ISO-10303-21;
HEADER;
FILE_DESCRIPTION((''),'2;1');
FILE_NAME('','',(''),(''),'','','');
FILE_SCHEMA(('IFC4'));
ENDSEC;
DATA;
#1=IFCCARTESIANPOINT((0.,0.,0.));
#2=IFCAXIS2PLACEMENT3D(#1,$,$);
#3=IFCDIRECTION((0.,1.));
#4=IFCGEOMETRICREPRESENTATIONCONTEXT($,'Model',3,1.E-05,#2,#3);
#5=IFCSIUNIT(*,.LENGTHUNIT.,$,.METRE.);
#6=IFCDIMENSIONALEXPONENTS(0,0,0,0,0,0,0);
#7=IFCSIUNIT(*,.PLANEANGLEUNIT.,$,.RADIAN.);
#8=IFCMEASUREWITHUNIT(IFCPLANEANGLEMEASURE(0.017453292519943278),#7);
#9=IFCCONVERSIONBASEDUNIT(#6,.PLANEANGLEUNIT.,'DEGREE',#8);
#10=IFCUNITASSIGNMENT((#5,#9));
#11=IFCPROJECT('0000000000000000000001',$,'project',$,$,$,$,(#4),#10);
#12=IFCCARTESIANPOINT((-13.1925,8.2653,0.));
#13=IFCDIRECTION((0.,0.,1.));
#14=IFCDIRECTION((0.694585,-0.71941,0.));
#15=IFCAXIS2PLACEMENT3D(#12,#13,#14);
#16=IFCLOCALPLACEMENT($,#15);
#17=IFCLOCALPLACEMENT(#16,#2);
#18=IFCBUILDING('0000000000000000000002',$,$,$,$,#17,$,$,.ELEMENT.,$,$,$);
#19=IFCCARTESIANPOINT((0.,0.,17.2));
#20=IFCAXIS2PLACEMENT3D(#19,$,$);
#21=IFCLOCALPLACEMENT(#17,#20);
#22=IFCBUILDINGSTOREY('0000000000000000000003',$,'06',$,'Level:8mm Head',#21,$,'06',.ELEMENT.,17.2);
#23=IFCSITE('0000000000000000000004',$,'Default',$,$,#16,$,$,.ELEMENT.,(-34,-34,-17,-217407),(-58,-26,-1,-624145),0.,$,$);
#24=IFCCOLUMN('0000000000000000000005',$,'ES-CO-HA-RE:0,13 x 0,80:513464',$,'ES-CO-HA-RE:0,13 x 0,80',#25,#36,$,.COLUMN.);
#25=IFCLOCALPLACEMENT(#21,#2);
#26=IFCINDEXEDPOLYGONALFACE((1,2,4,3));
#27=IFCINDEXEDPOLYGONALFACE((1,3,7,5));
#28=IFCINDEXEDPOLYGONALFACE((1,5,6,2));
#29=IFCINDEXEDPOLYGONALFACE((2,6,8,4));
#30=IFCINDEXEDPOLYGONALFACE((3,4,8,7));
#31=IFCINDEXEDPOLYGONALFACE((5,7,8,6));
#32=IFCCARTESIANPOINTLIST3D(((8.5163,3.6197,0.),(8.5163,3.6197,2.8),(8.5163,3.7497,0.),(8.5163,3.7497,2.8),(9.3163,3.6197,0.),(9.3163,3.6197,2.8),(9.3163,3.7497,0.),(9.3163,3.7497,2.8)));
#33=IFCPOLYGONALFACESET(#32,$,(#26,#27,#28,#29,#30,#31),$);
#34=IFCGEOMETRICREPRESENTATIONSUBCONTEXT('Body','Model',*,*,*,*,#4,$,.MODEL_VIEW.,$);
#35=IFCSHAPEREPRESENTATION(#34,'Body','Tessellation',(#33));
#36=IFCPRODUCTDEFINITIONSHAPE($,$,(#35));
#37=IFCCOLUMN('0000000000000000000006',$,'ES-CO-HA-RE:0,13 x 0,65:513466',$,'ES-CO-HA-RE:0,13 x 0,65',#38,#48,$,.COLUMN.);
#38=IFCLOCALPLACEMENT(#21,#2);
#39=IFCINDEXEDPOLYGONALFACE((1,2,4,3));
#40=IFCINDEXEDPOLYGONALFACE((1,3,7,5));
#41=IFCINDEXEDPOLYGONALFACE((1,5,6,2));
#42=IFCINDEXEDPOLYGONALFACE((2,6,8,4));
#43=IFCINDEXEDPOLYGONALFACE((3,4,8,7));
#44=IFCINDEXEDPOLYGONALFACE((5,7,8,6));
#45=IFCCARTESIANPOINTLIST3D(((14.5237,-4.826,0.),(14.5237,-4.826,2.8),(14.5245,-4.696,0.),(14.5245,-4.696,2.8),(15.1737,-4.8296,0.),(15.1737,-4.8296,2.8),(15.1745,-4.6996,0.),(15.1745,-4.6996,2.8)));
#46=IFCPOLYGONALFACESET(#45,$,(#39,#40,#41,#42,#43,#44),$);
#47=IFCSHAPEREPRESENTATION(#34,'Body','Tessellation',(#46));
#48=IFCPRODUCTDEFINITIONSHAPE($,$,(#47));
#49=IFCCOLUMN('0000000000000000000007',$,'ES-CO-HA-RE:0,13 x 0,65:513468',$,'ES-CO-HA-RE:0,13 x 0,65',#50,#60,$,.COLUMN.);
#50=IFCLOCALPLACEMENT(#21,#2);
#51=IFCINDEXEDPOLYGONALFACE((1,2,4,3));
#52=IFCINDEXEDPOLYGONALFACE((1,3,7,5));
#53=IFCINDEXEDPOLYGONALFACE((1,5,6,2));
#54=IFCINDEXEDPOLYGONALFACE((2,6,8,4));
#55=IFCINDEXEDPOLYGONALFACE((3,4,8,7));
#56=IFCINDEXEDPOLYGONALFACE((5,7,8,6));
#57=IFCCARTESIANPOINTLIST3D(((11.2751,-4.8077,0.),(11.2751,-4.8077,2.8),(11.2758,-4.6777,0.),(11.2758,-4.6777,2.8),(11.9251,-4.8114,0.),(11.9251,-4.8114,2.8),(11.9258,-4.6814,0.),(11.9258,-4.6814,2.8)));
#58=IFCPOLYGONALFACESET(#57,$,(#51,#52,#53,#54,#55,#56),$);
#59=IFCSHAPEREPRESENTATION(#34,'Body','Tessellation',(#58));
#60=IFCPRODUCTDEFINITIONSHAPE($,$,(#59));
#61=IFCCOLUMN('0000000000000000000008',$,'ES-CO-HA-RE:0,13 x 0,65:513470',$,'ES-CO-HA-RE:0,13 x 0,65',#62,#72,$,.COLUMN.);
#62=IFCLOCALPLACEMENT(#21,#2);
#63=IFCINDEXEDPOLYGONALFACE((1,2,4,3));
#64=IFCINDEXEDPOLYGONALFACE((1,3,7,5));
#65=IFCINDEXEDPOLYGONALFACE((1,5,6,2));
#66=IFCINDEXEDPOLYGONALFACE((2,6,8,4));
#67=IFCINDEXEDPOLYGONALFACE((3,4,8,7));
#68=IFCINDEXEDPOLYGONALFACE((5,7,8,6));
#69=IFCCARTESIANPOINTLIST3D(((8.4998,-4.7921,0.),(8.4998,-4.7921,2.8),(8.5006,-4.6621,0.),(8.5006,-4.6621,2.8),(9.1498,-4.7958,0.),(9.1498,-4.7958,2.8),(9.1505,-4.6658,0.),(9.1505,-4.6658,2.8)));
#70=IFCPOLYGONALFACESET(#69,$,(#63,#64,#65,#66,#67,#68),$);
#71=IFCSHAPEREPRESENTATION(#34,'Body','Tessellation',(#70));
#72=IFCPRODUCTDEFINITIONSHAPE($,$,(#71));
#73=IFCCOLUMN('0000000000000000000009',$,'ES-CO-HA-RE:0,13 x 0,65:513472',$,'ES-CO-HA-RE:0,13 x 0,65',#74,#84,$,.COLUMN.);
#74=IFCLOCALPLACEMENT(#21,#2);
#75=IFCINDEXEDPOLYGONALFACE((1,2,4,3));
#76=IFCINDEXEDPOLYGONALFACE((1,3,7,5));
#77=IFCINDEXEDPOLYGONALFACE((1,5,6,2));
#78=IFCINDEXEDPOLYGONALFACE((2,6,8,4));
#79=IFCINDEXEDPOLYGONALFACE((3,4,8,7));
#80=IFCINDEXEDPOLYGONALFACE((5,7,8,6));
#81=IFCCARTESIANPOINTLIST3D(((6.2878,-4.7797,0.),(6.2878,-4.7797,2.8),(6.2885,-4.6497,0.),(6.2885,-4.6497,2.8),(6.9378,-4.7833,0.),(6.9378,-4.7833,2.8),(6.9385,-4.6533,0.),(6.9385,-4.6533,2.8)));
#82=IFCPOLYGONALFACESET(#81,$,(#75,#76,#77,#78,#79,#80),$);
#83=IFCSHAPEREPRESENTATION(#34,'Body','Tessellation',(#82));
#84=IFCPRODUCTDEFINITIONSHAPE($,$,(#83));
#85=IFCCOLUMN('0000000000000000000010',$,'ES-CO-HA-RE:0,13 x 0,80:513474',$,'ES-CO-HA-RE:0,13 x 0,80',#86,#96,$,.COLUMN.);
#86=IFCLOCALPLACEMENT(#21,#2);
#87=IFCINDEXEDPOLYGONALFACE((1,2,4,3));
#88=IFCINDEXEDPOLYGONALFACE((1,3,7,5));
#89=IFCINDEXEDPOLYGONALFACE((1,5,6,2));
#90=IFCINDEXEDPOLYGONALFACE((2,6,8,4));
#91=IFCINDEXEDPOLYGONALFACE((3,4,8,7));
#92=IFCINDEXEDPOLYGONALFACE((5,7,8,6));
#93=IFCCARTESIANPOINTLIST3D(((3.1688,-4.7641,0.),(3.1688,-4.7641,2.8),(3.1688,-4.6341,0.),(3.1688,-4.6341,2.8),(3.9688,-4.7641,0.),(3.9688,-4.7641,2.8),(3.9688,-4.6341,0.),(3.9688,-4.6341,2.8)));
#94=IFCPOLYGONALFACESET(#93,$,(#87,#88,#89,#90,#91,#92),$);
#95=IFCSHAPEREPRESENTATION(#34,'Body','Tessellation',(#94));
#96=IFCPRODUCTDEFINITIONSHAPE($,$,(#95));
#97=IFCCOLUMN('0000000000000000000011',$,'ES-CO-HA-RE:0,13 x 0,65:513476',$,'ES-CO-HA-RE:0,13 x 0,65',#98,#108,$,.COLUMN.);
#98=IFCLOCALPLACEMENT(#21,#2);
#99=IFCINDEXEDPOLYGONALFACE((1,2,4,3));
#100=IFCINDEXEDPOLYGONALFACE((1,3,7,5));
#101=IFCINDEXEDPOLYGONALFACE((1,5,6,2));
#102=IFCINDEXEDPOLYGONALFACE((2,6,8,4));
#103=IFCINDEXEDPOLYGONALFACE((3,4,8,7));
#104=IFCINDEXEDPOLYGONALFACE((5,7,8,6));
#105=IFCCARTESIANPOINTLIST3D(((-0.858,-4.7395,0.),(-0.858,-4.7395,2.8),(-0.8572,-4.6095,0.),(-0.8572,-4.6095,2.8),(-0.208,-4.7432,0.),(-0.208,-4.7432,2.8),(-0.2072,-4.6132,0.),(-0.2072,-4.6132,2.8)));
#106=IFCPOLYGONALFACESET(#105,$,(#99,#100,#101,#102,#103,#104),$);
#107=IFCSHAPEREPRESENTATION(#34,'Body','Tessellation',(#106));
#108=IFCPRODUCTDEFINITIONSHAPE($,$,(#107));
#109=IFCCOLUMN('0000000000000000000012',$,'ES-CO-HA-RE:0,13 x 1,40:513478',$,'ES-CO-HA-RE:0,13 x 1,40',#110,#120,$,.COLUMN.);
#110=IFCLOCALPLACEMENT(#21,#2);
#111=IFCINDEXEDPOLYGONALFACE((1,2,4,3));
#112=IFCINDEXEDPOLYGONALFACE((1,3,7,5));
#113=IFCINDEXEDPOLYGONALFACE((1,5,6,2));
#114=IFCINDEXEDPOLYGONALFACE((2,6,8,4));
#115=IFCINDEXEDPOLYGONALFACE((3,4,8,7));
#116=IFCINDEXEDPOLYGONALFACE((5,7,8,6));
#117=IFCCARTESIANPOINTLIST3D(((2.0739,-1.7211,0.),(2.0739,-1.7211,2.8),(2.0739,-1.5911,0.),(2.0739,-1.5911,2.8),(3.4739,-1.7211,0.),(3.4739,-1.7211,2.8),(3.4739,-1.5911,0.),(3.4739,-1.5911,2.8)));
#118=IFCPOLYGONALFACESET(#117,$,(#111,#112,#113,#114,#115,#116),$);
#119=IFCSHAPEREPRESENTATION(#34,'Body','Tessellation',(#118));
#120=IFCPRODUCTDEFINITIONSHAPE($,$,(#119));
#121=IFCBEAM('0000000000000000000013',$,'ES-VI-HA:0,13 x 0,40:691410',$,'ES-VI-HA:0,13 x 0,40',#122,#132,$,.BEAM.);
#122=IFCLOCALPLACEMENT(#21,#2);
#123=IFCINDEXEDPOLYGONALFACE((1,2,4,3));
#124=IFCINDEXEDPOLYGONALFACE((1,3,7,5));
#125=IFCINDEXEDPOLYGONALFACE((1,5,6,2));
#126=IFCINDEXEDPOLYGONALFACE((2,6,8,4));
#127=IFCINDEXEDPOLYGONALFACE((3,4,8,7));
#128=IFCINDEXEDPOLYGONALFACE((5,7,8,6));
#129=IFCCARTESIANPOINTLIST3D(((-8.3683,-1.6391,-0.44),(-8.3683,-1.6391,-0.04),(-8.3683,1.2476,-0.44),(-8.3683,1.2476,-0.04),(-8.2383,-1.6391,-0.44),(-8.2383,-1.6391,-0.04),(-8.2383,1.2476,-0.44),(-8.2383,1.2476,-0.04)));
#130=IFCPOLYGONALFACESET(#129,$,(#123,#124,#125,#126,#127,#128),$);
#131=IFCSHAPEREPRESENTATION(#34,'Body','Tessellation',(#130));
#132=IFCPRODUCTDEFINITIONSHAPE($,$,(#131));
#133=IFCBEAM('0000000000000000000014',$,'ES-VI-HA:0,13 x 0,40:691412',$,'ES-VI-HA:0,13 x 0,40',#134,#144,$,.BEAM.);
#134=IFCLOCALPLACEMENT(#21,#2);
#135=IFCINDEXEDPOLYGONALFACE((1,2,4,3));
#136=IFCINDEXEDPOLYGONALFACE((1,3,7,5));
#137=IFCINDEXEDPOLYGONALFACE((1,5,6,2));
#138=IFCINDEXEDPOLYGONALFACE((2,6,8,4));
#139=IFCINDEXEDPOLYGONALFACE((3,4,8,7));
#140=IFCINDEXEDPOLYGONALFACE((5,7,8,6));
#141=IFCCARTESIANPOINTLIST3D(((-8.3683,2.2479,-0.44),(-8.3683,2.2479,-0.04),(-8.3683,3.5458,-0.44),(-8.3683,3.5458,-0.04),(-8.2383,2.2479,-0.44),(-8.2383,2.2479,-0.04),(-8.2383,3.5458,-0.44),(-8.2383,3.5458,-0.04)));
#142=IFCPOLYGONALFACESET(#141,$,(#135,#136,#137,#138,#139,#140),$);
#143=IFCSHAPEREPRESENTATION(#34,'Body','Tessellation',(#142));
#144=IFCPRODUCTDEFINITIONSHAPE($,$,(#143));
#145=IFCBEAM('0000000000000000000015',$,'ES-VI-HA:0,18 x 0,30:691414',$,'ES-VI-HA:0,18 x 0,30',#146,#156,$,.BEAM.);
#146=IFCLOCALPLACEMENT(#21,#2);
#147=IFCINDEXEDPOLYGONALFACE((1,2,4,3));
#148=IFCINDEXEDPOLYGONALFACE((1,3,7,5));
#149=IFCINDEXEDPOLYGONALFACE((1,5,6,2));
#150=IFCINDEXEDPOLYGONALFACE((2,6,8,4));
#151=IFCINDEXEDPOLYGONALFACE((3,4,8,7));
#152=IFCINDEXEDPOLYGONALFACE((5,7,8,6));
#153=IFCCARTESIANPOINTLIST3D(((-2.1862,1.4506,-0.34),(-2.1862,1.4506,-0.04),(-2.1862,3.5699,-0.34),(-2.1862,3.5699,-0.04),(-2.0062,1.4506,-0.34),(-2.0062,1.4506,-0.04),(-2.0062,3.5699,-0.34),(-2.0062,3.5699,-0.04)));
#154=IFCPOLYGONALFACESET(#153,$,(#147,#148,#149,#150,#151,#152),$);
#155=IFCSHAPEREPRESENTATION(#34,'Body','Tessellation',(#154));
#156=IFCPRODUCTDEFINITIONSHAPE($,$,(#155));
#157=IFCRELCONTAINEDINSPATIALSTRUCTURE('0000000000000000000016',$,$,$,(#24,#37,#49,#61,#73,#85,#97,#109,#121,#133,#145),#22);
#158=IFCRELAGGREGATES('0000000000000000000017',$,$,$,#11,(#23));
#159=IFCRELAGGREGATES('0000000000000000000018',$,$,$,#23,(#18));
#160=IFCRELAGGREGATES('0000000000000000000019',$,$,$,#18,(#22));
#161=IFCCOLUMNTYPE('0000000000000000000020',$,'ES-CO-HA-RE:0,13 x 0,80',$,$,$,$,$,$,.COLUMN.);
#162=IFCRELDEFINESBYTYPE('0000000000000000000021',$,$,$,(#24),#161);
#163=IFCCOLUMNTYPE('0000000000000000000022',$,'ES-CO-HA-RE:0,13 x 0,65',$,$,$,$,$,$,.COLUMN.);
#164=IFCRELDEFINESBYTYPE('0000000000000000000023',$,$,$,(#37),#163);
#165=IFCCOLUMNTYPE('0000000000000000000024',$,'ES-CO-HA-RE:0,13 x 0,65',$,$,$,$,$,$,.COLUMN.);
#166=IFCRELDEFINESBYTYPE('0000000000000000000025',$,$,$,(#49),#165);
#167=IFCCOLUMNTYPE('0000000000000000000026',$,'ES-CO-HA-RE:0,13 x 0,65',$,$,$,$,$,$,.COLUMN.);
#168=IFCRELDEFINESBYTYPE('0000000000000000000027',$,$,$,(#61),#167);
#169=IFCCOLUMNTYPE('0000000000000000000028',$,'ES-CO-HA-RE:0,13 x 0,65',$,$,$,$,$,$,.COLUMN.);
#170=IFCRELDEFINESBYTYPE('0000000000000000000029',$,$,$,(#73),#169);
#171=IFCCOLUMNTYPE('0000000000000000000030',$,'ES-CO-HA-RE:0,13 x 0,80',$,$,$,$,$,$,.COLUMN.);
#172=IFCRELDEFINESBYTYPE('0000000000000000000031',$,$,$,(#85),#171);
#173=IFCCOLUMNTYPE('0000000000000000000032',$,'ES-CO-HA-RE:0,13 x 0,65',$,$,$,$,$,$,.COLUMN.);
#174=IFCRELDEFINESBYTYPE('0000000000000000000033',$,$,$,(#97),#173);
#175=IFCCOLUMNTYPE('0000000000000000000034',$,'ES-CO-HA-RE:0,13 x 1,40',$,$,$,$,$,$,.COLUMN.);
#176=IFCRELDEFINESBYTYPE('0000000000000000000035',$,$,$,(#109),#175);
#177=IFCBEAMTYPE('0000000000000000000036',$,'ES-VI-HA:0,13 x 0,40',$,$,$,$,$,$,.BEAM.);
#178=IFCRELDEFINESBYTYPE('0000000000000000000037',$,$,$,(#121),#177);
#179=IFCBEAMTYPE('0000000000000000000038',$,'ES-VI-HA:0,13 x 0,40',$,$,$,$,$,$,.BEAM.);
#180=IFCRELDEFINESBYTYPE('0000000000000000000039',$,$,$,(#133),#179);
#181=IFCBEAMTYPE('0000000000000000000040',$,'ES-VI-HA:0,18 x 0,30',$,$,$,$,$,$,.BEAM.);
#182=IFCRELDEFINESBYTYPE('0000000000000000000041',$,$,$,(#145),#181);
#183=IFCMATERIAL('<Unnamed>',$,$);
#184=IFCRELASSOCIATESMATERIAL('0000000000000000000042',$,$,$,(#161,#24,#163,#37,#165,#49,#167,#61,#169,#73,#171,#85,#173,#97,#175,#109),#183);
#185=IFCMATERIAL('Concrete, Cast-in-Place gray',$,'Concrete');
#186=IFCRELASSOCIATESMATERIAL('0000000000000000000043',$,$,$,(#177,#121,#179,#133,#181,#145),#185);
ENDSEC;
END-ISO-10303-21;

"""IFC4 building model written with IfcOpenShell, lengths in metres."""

from ifc_helpers import new_model, entity, si_unit, converted_unit, direction, frame, origin, place, context, subcontext, project, spatial, indexed_curve, outline, extrude, source, transform, mapped, material, type_object, type_shapes, element, save


model = new_model("IFC4")

# Units and contexts
model_context = context("Model", 3, precision=1e-05, world=origin(), true_north=direction((0.0, 1.0)))
body_context = subcontext(model_context, "Body", "Model", "MODEL_VIEW")
ifc_project = project(units=[si_unit("LENGTHUNIT", "METRE"), converted_unit("PLANEANGLEUNIT", "DEGREE", entity("IfcPlaneAngleMeasure", 0.017453292519943278), si_unit("PLANEANGLEUNIT", "RADIAN"), dimensions=[0, 0, 0, 0, 0, 0, 0])], contexts=[model_context])

# Site, building, storey
site_placement = place(None, frame((-13.1925, 8.2653, 0.0), z_axis=(0.0, 0.0, 1.0), x_axis=(0.694585, -0.71941, 0.0)))
site = spatial("IfcSite", under=ifc_project, at=site_placement, Name="Default", CompositionType="ELEMENT", RefLatitude=(-34, -34, -17, -217407), RefLongitude=(-58, -26, -1, -624145), RefElevation=0.0)
building_placement = place(site_placement, origin())
building = spatial("IfcBuilding", under=site, at=building_placement, CompositionType="ELEMENT")
storey_placement = place(building_placement, frame((0.0, 0.0, 17.2)))
storey = spatial("IfcBuildingStorey", under=building, at=storey_placement, Name="06", ObjectType="Level:8mm Head", LongName="06", CompositionType="ELEMENT", Elevation=17.2)

# Columns
ifc_material_1 = material(Name="<Unnamed>")
column_type_1 = type_object("IfcColumnType", Name="ES-CO-HA-RE:0,13 x 0,80", PredefinedType="COLUMN", material=ifc_material_1)
shared_shape_1 = source(origin(), body_context, "Body", "SweptSolid", [
    extrude(outline(indexed_curve([(-0.4, -0.065), (0.4, -0.065), (0.4, 0.065), (-0.4, 0.065), (-0.4, -0.065)], self_intersect=False)), frame((8.9163, 3.6847, 17.2), z_axis=(0.0, 0.0, 1.0), x_axis=(-1.0, 0.0, 0.0)), (0.0, 0.0, 1.0), 2.8),
])
type_shapes(column_type_1, [shared_shape_1])
column_1_placement = place(storey_placement, frame((0.0, 0.0, -17.2)))
element("IfcColumn", 1, at=column_1_placement, inside=storey, type_object=column_type_1, material=ifc_material_1, Name="ES-CO-HA-RE:0,13 x 0,80:513464", ObjectType="ES-CO-HA-RE:0,13 x 0,80", PredefinedType="COLUMN", context=body_context, shape_type="MappedRepresentation", body=[
    mapped(shared_shape_1, transform((0.0, 0.0, 0.0), scale=1.0)),
])
column_type_2 = type_object("IfcColumnType", Name="ES-CO-HA-RE:0,13 x 0,65", PredefinedType="COLUMN", material=ifc_material_1)
shared_shape_2 = source(origin(), body_context, "Body", "SweptSolid", [
    extrude(outline(indexed_curve([(-0.325, -0.065), (0.325, -0.065), (0.325, 0.065), (-0.325, 0.065), (-0.325, -0.065)], self_intersect=False)), frame((14.8491, -4.7628, 17.2), z_axis=(0.0, 0.0, 1.0), x_axis=(-0.999984, 0.005619, 0.0)), (0.0, 0.0, 1.0), 2.8),
])
type_shapes(column_type_2, [shared_shape_2])
column_2_placement = place(storey_placement, frame((0.0, 0.0, -17.2)))
element("IfcColumn", 2, at=column_2_placement, inside=storey, type_object=column_type_2, material=ifc_material_1, Name="ES-CO-HA-RE:0,13 x 0,65:513466", ObjectType="ES-CO-HA-RE:0,13 x 0,65", PredefinedType="COLUMN", context=body_context, shape_type="MappedRepresentation", body=[
    mapped(shared_shape_2, transform((0.0, 0.0, 0.0), scale=1.0)),
])
column_type_3 = type_object("IfcColumnType", Name="ES-CO-HA-RE:0,13 x 0,65", PredefinedType="COLUMN", material=ifc_material_1)
shared_shape_3 = source(origin(), body_context, "Body", "SweptSolid", [
    extrude(outline(indexed_curve([(-0.325, -0.065), (0.325, -0.065), (0.325, 0.065), (-0.325, 0.065), (-0.325, -0.065)], self_intersect=False)), frame((11.6005, -4.7445, 17.2), z_axis=(0.0, 0.0, 1.0), x_axis=(-0.999984, 0.005619, 0.0)), (0.0, 0.0, 1.0), 2.8),
])
type_shapes(column_type_3, [shared_shape_3])
column_3_placement = place(storey_placement, frame((0.0, 0.0, -17.2)))
element("IfcColumn", 3, at=column_3_placement, inside=storey, type_object=column_type_3, material=ifc_material_1, Name="ES-CO-HA-RE:0,13 x 0,65:513468", ObjectType="ES-CO-HA-RE:0,13 x 0,65", PredefinedType="COLUMN", context=body_context, shape_type="MappedRepresentation", body=[
    mapped(shared_shape_3, transform((0.0, 0.0, 0.0), scale=1.0)),
])
column_type_4 = type_object("IfcColumnType", Name="ES-CO-HA-RE:0,13 x 0,65", PredefinedType="COLUMN", material=ifc_material_1)
shared_shape_4 = source(origin(), body_context, "Body", "SweptSolid", [
    extrude(outline(indexed_curve([(-0.325, -0.065), (0.325, -0.065), (0.325, 0.065), (-0.325, 0.065), (-0.325, -0.065)], self_intersect=False)), frame((8.8252, -4.7289, 17.2), z_axis=(0.0, 0.0, 1.0), x_axis=(-0.999984, 0.005619, 0.0)), (0.0, 0.0, 1.0), 2.8),
])
type_shapes(column_type_4, [shared_shape_4])
column_4_placement = place(storey_placement, frame((0.0, 0.0, -17.2)))
element("IfcColumn", 4, at=column_4_placement, inside=storey, type_object=column_type_4, material=ifc_material_1, Name="ES-CO-HA-RE:0,13 x 0,65:513470", ObjectType="ES-CO-HA-RE:0,13 x 0,65", PredefinedType="COLUMN", context=body_context, shape_type="MappedRepresentation", body=[
    mapped(shared_shape_4, transform((0.0, 0.0, 0.0), scale=1.0)),
])
column_type_5 = type_object("IfcColumnType", Name="ES-CO-HA-RE:0,13 x 0,65", PredefinedType="COLUMN", material=ifc_material_1)
shared_shape_5 = source(origin(), body_context, "Body", "SweptSolid", [
    extrude(outline(indexed_curve([(-0.325, -0.065), (0.325, -0.065), (0.325, 0.065), (-0.325, 0.065), (-0.325, -0.065)], self_intersect=False)), frame((6.6131, -4.7165, 17.2), z_axis=(0.0, 0.0, 1.0), x_axis=(-0.999984, 0.005619, 0.0)), (0.0, 0.0, 1.0), 2.8),
])
type_shapes(column_type_5, [shared_shape_5])
column_5_placement = place(storey_placement, frame((0.0, 0.0, -17.2)))
element("IfcColumn", 5, at=column_5_placement, inside=storey, type_object=column_type_5, material=ifc_material_1, Name="ES-CO-HA-RE:0,13 x 0,65:513472", ObjectType="ES-CO-HA-RE:0,13 x 0,65", PredefinedType="COLUMN", context=body_context, shape_type="MappedRepresentation", body=[
    mapped(shared_shape_5, transform((0.0, 0.0, 0.0), scale=1.0)),
])
column_type_6 = type_object("IfcColumnType", Name="ES-CO-HA-RE:0,13 x 0,80", PredefinedType="COLUMN", material=ifc_material_1)
shared_shape_6 = source(origin(), body_context, "Body", "SweptSolid", [
    extrude(outline(indexed_curve([(-0.4, -0.065), (0.4, -0.065), (0.4, 0.065), (-0.4, 0.065), (-0.4, -0.065)], self_intersect=False)), frame((3.5688, -4.6991, 17.2), z_axis=(0.0, 0.0, 1.0), x_axis=(-1.0, 0.0, 0.0)), (0.0, 0.0, 1.0), 2.8),
])
type_shapes(column_type_6, [shared_shape_6])
column_6_placement = place(storey_placement, frame((0.0, 0.0, -17.2)))
element("IfcColumn", 6, at=column_6_placement, inside=storey, type_object=column_type_6, material=ifc_material_1, Name="ES-CO-HA-RE:0,13 x 0,80:513474", ObjectType="ES-CO-HA-RE:0,13 x 0,80", PredefinedType="COLUMN", context=body_context, shape_type="MappedRepresentation", body=[
    mapped(shared_shape_6, transform((0.0, 0.0, 0.0), scale=1.0)),
])
column_type_7 = type_object("IfcColumnType", Name="ES-CO-HA-RE:0,13 x 0,65", PredefinedType="COLUMN", material=ifc_material_1)
shared_shape_7 = source(origin(), body_context, "Body", "SweptSolid", [
    extrude(outline(indexed_curve([(-0.325, -0.065), (0.325, -0.065), (0.325, 0.065), (-0.325, 0.065), (-0.325, -0.065)], self_intersect=False)), frame((-0.5326, -4.6764, 17.2), z_axis=(0.0, 0.0, 1.0), x_axis=(-0.999984, 0.005619, 0.0)), (0.0, 0.0, 1.0), 2.8),
])
type_shapes(column_type_7, [shared_shape_7])
column_7_placement = place(storey_placement, frame((0.0, 0.0, -17.2)))
element("IfcColumn", 7, at=column_7_placement, inside=storey, type_object=column_type_7, material=ifc_material_1, Name="ES-CO-HA-RE:0,13 x 0,65:513476", ObjectType="ES-CO-HA-RE:0,13 x 0,65", PredefinedType="COLUMN", context=body_context, shape_type="MappedRepresentation", body=[
    mapped(shared_shape_7, transform((0.0, 0.0, 0.0), scale=1.0)),
])
column_type_8 = type_object("IfcColumnType", Name="ES-CO-HA-RE:0,13 x 1,40", PredefinedType="COLUMN", material=ifc_material_1)
shared_shape_8 = source(origin(), body_context, "Body", "SweptSolid", [
    extrude(outline(indexed_curve([(-0.7, -0.065), (0.7, -0.065), (0.7, 0.065), (-0.7, 0.065), (-0.7, -0.065)], self_intersect=False)), frame((2.7739, -1.6561, 17.2), z_axis=(0.0, 0.0, 1.0), x_axis=(-1.0, 0.0, 0.0)), (0.0, 0.0, 1.0), 2.8),
])
type_shapes(column_type_8, [shared_shape_8])
column_8_placement = place(storey_placement, frame((0.0, 0.0, -17.2)))
element("IfcColumn", 8, at=column_8_placement, inside=storey, type_object=column_type_8, material=ifc_material_1, Name="ES-CO-HA-RE:0,13 x 1,40:513478", ObjectType="ES-CO-HA-RE:0,13 x 1,40", PredefinedType="COLUMN", context=body_context, shape_type="MappedRepresentation", body=[
    mapped(shared_shape_8, transform((0.0, 0.0, 0.0), scale=1.0)),
])

# Beams
ifc_material_2 = material(Name="Concrete, Cast-in-Place gray", Category="Concrete")
beam_type_1 = type_object("IfcBeamType", Name="ES-VI-HA:0,13 x 0,40", PredefinedType="BEAM", material=ifc_material_2)
shared_shape_9 = source(origin(), body_context, "Body", "SweptSolid", [
    extrude(outline(indexed_curve([(-0.065, -0.2), (0.065, -0.2), (0.065, 0.2), (-0.065, 0.2), (-0.065, -0.2)], self_intersect=False)), frame((-8.3033, -1.6391, 16.96), z_axis=(0.0, 1.0, 0.0), x_axis=(-1.0, 0.0, 0.0)), (0.0, 0.0, 1.0), 2.8867),
])
type_shapes(beam_type_1, [shared_shape_9])
beam_1_placement = place(storey_placement, frame((0.0, 0.0, -17.2)))
element("IfcBeam", 9, at=beam_1_placement, inside=storey, type_object=beam_type_1, material=ifc_material_2, Name="ES-VI-HA:0,13 x 0,40:691410", ObjectType="ES-VI-HA:0,13 x 0,40", PredefinedType="BEAM", context=body_context, shape_type="MappedRepresentation", body=[
    mapped(shared_shape_9, transform((0.0, 0.0, 0.0), scale=1.0)),
])
beam_type_2 = type_object("IfcBeamType", Name="ES-VI-HA:0,13 x 0,40", PredefinedType="BEAM", material=ifc_material_2)
shared_shape_10 = source(origin(), body_context, "Body", "SweptSolid", [
    extrude(outline(indexed_curve([(-0.065, -0.2), (0.065, -0.2), (0.065, 0.2), (-0.065, 0.2), (-0.065, -0.2)], self_intersect=False)), frame((-8.3033, 2.2479, 16.96), z_axis=(0.0, 1.0, 0.0), x_axis=(-1.0, 0.0, 0.0)), (0.0, 0.0, 1.0), 1.298),
])
type_shapes(beam_type_2, [shared_shape_10])
beam_2_placement = place(storey_placement, frame((0.0, 0.0, -17.2)))
element("IfcBeam", 10, at=beam_2_placement, inside=storey, type_object=beam_type_2, material=ifc_material_2, Name="ES-VI-HA:0,13 x 0,40:691412", ObjectType="ES-VI-HA:0,13 x 0,40", PredefinedType="BEAM", context=body_context, shape_type="MappedRepresentation", body=[
    mapped(shared_shape_10, transform((0.0, 0.0, 0.0), scale=1.0)),
])
beam_type_3 = type_object("IfcBeamType", Name="ES-VI-HA:0,18 x 0,30", PredefinedType="BEAM", material=ifc_material_2)
shared_shape_11 = source(origin(), body_context, "Body", "SweptSolid", [
    extrude(outline(indexed_curve([(-0.09, -0.15), (0.09, -0.15), (0.09, 0.15), (-0.09, 0.15), (-0.09, -0.15)], self_intersect=False)), frame((-2.0962, 3.5699, 17.01), z_axis=(0.0, -1.0, 0.0), x_axis=(-1.0, 0.0, 0.0)), (0.0, 0.0, 1.0), 2.1193),
])
type_shapes(beam_type_3, [shared_shape_11])
beam_3_placement = place(storey_placement, frame((0.0, 0.0, -17.2)))
element("IfcBeam", 11, at=beam_3_placement, inside=storey, type_object=beam_type_3, material=ifc_material_2, Name="ES-VI-HA:0,18 x 0,30:691414", ObjectType="ES-VI-HA:0,18 x 0,30", PredefinedType="BEAM", context=body_context, shape_type="MappedRepresentation", body=[
    mapped(shared_shape_11, transform((0.0, 0.0, 0.0), scale=1.0)),
])

save(model, "model.ifc")
